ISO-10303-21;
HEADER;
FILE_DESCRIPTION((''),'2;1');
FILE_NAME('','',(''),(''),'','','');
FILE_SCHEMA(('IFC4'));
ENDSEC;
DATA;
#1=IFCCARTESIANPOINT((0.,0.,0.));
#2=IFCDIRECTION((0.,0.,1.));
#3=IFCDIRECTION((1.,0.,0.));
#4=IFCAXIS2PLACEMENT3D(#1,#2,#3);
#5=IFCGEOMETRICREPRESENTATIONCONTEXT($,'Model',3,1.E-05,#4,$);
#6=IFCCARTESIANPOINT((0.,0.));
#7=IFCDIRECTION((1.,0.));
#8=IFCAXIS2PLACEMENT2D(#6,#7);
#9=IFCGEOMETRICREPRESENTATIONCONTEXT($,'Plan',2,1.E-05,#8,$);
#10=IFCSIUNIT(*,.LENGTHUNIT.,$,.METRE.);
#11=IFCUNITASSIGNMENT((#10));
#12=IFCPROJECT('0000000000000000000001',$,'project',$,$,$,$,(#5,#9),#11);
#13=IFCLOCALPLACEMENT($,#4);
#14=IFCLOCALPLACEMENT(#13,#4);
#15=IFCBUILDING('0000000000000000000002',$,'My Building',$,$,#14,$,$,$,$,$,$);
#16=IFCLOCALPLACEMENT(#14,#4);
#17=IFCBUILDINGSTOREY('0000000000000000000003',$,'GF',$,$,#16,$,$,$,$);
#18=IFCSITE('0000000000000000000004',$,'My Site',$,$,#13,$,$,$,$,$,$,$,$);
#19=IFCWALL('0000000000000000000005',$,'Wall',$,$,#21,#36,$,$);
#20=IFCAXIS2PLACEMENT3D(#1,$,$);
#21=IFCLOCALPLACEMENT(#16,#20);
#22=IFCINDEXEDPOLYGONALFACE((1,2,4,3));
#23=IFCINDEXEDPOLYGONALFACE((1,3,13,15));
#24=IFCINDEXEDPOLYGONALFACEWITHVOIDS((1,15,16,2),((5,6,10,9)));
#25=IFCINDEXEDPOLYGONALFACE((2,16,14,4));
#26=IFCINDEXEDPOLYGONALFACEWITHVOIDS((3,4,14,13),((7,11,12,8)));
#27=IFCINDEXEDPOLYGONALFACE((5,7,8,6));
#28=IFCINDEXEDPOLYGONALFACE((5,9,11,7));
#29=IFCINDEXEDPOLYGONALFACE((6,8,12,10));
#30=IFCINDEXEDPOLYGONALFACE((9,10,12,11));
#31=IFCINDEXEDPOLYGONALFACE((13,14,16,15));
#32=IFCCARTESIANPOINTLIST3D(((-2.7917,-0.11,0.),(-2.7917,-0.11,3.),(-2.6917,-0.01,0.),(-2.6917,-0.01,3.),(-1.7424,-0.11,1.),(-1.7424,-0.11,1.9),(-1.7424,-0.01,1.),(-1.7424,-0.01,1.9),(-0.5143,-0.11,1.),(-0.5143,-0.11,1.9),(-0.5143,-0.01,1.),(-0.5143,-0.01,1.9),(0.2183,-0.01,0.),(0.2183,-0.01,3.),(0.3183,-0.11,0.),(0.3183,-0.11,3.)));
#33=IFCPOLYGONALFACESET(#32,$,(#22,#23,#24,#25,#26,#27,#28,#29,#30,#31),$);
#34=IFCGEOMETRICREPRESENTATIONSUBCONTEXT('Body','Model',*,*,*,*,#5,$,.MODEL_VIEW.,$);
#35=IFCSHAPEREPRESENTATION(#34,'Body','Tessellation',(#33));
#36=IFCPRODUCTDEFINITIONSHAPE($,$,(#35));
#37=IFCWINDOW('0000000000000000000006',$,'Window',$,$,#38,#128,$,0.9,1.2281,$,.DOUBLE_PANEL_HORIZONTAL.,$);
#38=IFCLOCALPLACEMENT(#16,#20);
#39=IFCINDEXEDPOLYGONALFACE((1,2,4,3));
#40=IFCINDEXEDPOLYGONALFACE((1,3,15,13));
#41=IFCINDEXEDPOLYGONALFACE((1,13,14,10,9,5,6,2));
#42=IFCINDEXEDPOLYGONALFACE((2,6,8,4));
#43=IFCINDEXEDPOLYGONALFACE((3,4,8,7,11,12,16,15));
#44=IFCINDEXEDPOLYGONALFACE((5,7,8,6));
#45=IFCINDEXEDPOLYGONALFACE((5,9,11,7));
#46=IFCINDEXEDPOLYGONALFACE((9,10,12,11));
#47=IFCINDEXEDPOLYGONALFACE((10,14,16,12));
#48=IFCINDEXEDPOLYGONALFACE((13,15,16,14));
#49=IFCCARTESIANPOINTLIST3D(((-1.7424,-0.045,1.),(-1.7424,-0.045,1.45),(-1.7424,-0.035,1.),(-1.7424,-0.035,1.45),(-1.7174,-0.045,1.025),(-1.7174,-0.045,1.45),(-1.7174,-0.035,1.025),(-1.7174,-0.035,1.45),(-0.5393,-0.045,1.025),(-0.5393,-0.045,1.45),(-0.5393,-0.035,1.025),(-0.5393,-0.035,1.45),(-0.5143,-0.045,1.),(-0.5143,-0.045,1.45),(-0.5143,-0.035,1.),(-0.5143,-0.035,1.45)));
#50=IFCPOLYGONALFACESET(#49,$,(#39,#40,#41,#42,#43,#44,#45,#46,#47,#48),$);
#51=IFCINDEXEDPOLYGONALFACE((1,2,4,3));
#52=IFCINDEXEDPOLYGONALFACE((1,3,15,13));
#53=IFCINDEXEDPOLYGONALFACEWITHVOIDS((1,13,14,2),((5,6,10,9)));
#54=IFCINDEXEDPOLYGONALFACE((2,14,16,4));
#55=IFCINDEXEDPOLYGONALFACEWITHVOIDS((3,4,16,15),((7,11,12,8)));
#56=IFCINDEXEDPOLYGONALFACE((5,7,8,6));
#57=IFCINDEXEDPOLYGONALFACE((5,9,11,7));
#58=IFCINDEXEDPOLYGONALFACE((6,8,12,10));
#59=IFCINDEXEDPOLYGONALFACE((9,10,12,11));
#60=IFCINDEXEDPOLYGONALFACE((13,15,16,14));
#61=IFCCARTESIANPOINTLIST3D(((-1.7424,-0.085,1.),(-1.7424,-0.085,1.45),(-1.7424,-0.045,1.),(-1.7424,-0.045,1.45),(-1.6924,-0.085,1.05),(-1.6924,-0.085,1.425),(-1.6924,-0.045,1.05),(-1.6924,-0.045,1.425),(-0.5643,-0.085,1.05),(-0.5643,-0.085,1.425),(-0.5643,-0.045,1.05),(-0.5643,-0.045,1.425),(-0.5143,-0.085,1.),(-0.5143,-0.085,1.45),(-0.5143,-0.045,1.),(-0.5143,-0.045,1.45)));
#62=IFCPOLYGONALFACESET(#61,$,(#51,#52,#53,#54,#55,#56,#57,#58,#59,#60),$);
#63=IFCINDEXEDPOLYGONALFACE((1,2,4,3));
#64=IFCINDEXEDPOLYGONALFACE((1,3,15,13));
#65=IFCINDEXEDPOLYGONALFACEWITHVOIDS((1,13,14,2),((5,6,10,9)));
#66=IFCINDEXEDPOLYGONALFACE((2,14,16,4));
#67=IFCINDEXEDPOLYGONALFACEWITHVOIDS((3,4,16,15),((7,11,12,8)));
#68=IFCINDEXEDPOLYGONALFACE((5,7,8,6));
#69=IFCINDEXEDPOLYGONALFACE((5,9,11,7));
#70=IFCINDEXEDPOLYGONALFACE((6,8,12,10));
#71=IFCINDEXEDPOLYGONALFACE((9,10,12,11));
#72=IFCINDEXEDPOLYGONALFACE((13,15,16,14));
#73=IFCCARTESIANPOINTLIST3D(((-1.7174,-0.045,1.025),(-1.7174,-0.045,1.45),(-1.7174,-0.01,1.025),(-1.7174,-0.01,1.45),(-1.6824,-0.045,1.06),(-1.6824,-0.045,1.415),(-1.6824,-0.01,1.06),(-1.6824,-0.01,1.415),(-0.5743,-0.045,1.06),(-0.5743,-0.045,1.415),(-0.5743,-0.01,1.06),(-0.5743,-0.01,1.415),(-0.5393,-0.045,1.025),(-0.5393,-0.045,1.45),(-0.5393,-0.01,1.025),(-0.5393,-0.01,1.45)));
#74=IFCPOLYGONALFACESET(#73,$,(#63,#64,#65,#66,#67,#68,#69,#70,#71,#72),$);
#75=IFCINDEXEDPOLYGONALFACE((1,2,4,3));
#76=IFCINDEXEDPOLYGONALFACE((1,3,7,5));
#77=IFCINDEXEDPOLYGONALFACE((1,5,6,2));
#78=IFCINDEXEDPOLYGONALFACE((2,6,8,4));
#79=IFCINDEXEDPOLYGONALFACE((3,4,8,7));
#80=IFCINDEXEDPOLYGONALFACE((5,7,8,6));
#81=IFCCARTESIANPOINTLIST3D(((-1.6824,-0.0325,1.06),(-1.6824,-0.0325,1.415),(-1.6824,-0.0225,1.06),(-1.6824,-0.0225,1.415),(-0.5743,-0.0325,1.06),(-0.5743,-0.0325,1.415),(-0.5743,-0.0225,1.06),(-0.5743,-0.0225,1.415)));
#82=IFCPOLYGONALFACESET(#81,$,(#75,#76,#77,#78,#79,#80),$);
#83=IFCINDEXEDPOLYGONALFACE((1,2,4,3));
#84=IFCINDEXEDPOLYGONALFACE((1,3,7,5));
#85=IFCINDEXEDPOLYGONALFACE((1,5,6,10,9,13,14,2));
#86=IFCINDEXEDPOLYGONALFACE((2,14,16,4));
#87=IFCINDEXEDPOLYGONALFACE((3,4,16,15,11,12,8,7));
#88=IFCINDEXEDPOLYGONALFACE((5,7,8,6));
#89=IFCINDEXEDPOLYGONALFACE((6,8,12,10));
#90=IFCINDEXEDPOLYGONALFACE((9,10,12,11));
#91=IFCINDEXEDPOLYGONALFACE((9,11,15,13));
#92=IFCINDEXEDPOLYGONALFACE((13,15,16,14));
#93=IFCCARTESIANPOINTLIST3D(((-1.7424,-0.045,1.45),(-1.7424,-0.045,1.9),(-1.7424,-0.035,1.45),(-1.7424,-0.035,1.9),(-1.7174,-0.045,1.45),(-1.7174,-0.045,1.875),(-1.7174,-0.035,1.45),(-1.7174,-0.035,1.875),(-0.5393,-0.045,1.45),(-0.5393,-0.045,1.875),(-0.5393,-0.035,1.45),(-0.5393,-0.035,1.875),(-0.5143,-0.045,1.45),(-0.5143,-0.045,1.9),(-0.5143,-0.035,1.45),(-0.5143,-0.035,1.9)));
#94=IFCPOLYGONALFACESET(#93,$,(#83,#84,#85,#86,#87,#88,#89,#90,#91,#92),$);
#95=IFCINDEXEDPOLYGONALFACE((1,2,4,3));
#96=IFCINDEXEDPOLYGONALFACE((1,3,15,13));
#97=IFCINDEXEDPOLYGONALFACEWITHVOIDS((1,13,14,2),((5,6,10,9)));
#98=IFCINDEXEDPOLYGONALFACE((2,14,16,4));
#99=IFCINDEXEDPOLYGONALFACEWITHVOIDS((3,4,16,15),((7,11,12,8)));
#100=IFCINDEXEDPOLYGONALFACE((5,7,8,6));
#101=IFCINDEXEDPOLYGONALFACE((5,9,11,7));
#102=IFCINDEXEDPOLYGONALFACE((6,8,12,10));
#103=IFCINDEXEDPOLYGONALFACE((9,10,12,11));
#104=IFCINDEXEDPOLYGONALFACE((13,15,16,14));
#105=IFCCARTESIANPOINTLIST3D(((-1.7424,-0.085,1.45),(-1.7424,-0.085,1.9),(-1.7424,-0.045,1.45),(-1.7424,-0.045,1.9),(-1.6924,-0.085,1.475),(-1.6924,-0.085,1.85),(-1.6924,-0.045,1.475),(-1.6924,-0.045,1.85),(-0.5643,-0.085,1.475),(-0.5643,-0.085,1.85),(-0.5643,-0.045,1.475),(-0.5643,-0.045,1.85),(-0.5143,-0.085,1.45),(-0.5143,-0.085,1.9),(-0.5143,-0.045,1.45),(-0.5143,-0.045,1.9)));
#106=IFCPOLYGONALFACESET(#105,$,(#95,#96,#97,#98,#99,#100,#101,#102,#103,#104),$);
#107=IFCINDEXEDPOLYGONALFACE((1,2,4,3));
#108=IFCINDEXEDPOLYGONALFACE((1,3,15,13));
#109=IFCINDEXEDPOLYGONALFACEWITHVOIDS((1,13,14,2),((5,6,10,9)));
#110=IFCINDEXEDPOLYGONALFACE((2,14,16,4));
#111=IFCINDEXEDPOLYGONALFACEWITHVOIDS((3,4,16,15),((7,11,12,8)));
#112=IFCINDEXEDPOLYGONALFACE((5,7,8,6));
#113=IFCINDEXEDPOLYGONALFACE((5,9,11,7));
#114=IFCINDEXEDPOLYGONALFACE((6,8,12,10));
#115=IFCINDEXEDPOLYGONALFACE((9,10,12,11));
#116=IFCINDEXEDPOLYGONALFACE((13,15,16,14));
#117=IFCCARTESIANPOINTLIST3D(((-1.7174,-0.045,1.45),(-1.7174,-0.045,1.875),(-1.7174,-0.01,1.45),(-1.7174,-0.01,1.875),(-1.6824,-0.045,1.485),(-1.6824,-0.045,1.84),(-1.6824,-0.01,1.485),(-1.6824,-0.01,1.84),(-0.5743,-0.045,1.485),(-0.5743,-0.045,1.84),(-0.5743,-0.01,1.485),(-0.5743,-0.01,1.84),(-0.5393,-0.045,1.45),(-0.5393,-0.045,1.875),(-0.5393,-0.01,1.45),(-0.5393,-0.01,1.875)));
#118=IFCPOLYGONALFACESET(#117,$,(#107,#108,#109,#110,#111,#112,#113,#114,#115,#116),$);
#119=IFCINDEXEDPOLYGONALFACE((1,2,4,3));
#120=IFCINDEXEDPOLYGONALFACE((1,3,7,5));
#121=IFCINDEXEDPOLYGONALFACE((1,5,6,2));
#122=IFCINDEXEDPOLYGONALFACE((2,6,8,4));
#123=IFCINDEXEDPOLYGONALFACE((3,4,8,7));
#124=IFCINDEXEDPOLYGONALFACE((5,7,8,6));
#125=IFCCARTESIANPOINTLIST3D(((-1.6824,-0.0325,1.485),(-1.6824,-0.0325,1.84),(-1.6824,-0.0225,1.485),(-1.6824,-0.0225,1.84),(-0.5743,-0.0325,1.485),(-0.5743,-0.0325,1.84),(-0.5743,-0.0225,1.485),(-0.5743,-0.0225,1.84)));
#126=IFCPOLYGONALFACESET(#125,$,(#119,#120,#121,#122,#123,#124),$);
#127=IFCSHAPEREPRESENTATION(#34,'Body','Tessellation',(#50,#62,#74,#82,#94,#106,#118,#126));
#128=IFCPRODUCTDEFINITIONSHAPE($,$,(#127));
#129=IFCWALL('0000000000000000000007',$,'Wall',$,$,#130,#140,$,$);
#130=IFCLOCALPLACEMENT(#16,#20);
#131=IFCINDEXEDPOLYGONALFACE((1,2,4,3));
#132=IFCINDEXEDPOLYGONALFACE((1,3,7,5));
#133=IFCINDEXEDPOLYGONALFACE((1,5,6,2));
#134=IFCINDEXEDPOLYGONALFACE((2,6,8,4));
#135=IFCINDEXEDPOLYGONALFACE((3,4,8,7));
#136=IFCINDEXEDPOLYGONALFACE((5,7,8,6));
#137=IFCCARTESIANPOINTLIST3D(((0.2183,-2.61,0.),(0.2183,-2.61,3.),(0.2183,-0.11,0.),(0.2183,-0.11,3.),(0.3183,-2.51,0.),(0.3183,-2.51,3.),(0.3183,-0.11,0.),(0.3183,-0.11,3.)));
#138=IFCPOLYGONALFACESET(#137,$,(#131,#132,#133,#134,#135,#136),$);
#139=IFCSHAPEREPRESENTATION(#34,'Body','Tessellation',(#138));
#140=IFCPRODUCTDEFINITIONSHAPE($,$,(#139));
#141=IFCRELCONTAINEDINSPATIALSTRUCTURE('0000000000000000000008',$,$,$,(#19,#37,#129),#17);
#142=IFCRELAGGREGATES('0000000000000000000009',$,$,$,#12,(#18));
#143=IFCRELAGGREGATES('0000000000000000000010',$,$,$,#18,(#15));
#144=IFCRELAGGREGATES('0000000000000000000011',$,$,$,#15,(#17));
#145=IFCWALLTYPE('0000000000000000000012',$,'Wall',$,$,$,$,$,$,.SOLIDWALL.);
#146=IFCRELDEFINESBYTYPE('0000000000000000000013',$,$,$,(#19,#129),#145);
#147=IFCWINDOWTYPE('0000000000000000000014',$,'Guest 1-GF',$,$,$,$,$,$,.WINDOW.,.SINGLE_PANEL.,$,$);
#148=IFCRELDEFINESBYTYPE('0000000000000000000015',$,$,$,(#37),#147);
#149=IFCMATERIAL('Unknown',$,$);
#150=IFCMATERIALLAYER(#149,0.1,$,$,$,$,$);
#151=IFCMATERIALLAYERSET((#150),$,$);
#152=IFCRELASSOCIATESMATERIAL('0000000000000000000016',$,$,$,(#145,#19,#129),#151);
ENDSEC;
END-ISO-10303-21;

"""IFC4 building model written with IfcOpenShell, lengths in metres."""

from ifc_helpers import new_model, entity, si_unit, frame, origin_with_axes, origin_2d_with_axis, place, context, subcontext, project, spatial, line, indexed_curve, outline, extrude, shape, source, transform, mapped, material, layer, layer_set, layer_usage, type_object, type_shapes, element, fill, save


model = new_model("IFC4")

# Units and contexts
model_context_1 = context("Model", 3, precision=1e-05, world=origin_with_axes())
plan_context = context("Plan", 2, precision=1e-05, world=origin_2d_with_axis())
body_context_1 = subcontext(model_context_1, "Body", "Model", "MODEL_VIEW")
body_context_2 = subcontext(plan_context, "Body", "Plan", "PLAN_VIEW")
ifc_project = project(units=[si_unit("LENGTHUNIT", "METRE")], contexts=[model_context_1, plan_context])

# Site, building, storey
site_placement = place(None, origin_with_axes())
site = spatial("IfcSite", under=ifc_project, at=site_placement, Name="My Site")
building_placement = place(site_placement, origin_with_axes())
building = spatial("IfcBuilding", under=site, at=building_placement, Name="My Building")
storey_placement = place(building_placement, origin_with_axes())
storey = spatial("IfcBuildingStorey", under=building, at=storey_placement, Name="GF")

# Shared definitions
ifc_material_1 = material(Name="Unknown")

# Shared definitions
ifc_layer_1 = layer(ifc_material_1, 0.1)
ifc_layer_set_1 = layer_set([ifc_layer_1])
wall_type = type_object("IfcWallType", Name="Wall", PredefinedType="SOLIDWALL", material=ifc_layer_set_1)

# Wall, opening, window
ifc_layer_usage_1 = layer_usage(ifc_layer_set_1, "AXIS2", "POSITIVE", 0.0)
wall_1_placement = place(storey_placement, frame((-2.7917, -0.11, 0.0), z_axis=(0.0, 0.0, 1.0), x_axis=(1.0, 0.0, 0.0)))
wall_1 = element("IfcWall", 1, at=wall_1_placement, inside=storey, type_object=wall_type, material=ifc_layer_usage_1, Name="Wall", context=body_context_1, shape_type="SweptSolid", body=[
    extrude(outline(indexed_curve([(0.0, 0.0), (0.1, 0.1), (3.01, 0.1), (3.11, 0.0)], segments=[line(1, 2, 3, 4, 1)])), origin_with_axes(), (0.0, 0.0, 1.0), 3.0),
])
shared_shape_1 = source(origin_with_axes(), body_context_1, "Body", "SweptSolid", [
    extrude(outline(indexed_curve([(0.0, 0.0), (1.2281, 0.0), (1.2281, 0.9), (0.0, 0.9)], segments=[line(1, 2, 3, 4, 1)])), frame((0.0, -0.6, 0.0), z_axis=(0.0, -1.0, 0.0), x_axis=(1.0, 0.0, 0.0)), (0.0, 0.0, -1.0), 1.2),
])
opening_1_placement = place(wall_1_placement, frame((1.0493, -0.025, 1.0), z_axis=(0.0, 0.0, 1.0), x_axis=(1.0, 0.0, 0.0)))
opening_1 = element("IfcOpeningElement", 2, at=opening_1_placement, cuts=wall_1, PredefinedType="OPENING", context=body_context_1, shape_type="MappedRepresentation", body=[
    mapped(shared_shape_1, transform((0.0, 0.0, 0.0), x_axis=(1.0, 0.0, 0.0), y_axis=(0.0, 1.0, 0.0), z_axis=(0.0, 0.0, 1.0), scale=1.0)),
])
window_type_1 = type_object("IfcWindowType", Name="Guest 1-GF", PartitioningType="SINGLE_PANEL", PredefinedType="WINDOW")
shared_shape_2 = source(origin_with_axes(), body_context_1, "Body", "SweptSolid", [
    extrude(outline(indexed_curve([(1.2281, 0.45), (1.2281, 0.0), (0.0, 0.0), (0.0, 0.45), (0.025, 0.45), (0.025, 0.025), (1.2031, 0.025), (1.2031, 0.45)], segments=[line(1, 2, 3, 4, 5, 6, 7, 8, 1)])), frame((0.0, 0.09, 0.0), z_axis=(0.0, -1.0, 0.0), x_axis=(1.0, 0.0, 0.0)), (0.0, 0.0, -1.0), 0.01),
    extrude(outline(indexed_curve([(0.0, 0.0), (1.2281, 0.0), (1.2281, 0.45), (0.0, 0.45)], segments=[line(1, 2, 3, 4, 1)]), holes=[indexed_curve([(0.05, 0.05), (1.1781, 0.05), (1.1781, 0.425), (0.05, 0.425)], segments=[line(1, 2, 3, 4, 1)])]), frame((0.0, 0.05, 0.0), z_axis=(0.0, -1.0, 0.0), x_axis=(1.0, 0.0, 0.0)), (0.0, 0.0, -1.0), 0.04),
    extrude(outline(indexed_curve([(0.0, 0.0), (1.1781, 0.0), (1.1781, 0.425), (0.0, 0.425)], segments=[line(1, 2, 3, 4, 1)]), holes=[indexed_curve([(0.035, 0.035), (1.1431, 0.035), (1.1431, 0.39), (0.035, 0.39)], segments=[line(1, 2, 3, 4, 1)])]), frame((0.025, 0.09, 0.025), z_axis=(0.0, -1.0, 0.0), x_axis=(1.0, 0.0, 0.0)), (0.0, 0.0, -1.0), 0.035),
    extrude(outline(indexed_curve([(0.035, 0.035), (1.1431, 0.035), (1.1431, 0.39), (0.035, 0.39)], segments=[line(1, 2, 3, 4, 1)])), frame((0.025, 0.1025, 0.025), z_axis=(0.0, -1.0, 0.0), x_axis=(1.0, 0.0, 0.0)), (0.0, 0.0, -1.0), 0.01),
    extrude(outline(indexed_curve([(0.0, 0.0), (0.0, 0.45), (1.2281, 0.45), (1.2281, 0.0), (1.2031, 0.0), (1.2031, 0.425), (0.025, 0.425), (0.025, 0.0)], segments=[line(1, 2, 3, 4, 5, 6, 7, 8, 1)])), frame((0.0, 0.09, 0.45), z_axis=(0.0, -1.0, 0.0), x_axis=(1.0, 0.0, 0.0)), (0.0, 0.0, -1.0), 0.01),
    extrude(outline(indexed_curve([(0.0, 0.0), (1.2281, 0.0), (1.2281, 0.45), (0.0, 0.45)], segments=[line(1, 2, 3, 4, 1)]), holes=[indexed_curve([(0.05, 0.025), (1.1781, 0.025), (1.1781, 0.4), (0.05, 0.4)], segments=[line(1, 2, 3, 4, 1)])]), frame((0.0, 0.05, 0.45), z_axis=(0.0, -1.0, 0.0), x_axis=(1.0, 0.0, 0.0)), (0.0, 0.0, -1.0), 0.04),
    extrude(outline(indexed_curve([(0.0, 0.0), (1.1781, 0.0), (1.1781, 0.425), (0.0, 0.425)], segments=[line(1, 2, 3, 4, 1)]), holes=[indexed_curve([(0.035, 0.035), (1.1431, 0.035), (1.1431, 0.39), (0.035, 0.39)], segments=[line(1, 2, 3, 4, 1)])]), frame((0.025, 0.09, 0.45), z_axis=(0.0, -1.0, 0.0), x_axis=(1.0, 0.0, 0.0)), (0.0, 0.0, -1.0), 0.035),
    extrude(outline(indexed_curve([(0.035, 0.035), (1.1431, 0.035), (1.1431, 0.39), (0.035, 0.39)], segments=[line(1, 2, 3, 4, 1)])), frame((0.025, 0.1025, 0.45), z_axis=(0.0, -1.0, 0.0), x_axis=(1.0, 0.0, 0.0)), (0.0, 0.0, -1.0), 0.01),
])
shared_shape_3 = source(origin_with_axes(), body_context_2, "Body", "Curve2D", [
    entity("IfcIndexedPolyCurve", entity("IfcCartesianPointList2D", [[0.05, 0.05], [1.1781, 0.05]])),
    entity("IfcIndexedPolyCurve", entity("IfcCartesianPointList2D", [[0.0, 0.1], [0.025, 0.1], [0.025, 0.09], [0.05, 0.09], [0.05, 0.05], [0.0, 0.05]]), [entity("IfcLineIndex", [1, 2, 3, 4, 5, 6, 1])]),
    entity("IfcIndexedPolyCurve", entity("IfcCartesianPointList2D", [[1.2281, 0.1], [1.2031, 0.1], [1.2031, 0.09], [1.1781, 0.09], [1.1781, 0.05], [1.2281, 0.05]]), [entity("IfcLineIndex", [1, 2, 3, 4, 5, 6, 1])]),
    entity("IfcIndexedPolyCurve", entity("IfcCartesianPointList2D", [[0.025, 0.09], [0.06, 0.09], [0.06, 0.125], [0.025, 0.125]]), [entity("IfcLineIndex", [1, 2, 3, 4, 1])]),
    entity("IfcIndexedPolyCurve", entity("IfcCartesianPointList2D", [[1.2031, 0.09], [1.1681, 0.09], [1.1681, 0.125], [1.2031, 0.125]]), [entity("IfcLineIndex", [1, 2, 3, 4, 1])]),
    entity("IfcIndexedPolyCurve", entity("IfcCartesianPointList2D", [[0.06, 0.09], [1.1681, 0.09]])),
    entity("IfcIndexedPolyCurve", entity("IfcCartesianPointList2D", [[0.06, 0.125], [1.1681, 0.125]])),
    entity("IfcIndexedPolyCurve", entity("IfcCartesianPointList2D", [[0.06, 0.1075], [1.1681, 0.1075]])),
])
type_shapes(window_type_1, [shared_shape_2, shared_shape_3])
window_1_placement = place(opening_1_placement, origin_with_axes())
window_1 = element("IfcWindow", 3, at=window_1_placement, inside=storey, type_object=window_type_1, Name="Window", OverallHeight=0.9, OverallWidth=1.2281, PartitioningType="DOUBLE_PANEL_HORIZONTAL", shapes=[
    shape(body_context_1, "Body", "MappedRepresentation", [mapped(shared_shape_2, transform((0.0, 0.0, 0.0), x_axis=(1.0, 0.0, 0.0), y_axis=(0.0, 1.0, 0.0), z_axis=(0.0, 0.0, 1.0), scale=1.0))]),
    shape(body_context_2, "Body", "MappedRepresentation", [mapped(shared_shape_3, transform((0.0, 0.0, 0.0), x_axis=(1.0, 0.0, 0.0), y_axis=(0.0, 1.0, 0.0), z_axis=(0.0, 0.0, 1.0), scale=1.0))]),
])
fill(opening_1, window_1)

# Wall
ifc_layer_usage_2 = layer_usage(ifc_layer_set_1, "AXIS2", "POSITIVE", 0.0)
wall_2_placement = place(storey_placement, frame((0.2183, -0.11, 0.0), z_axis=(0.0, 0.0, 1.0), x_axis=(0.0, -1.0, 0.0)))
element("IfcWall", 4, at=wall_2_placement, inside=storey, type_object=wall_type, material=ifc_layer_usage_2, Name="Wall", context=body_context_1, shape_type="SweptSolid", body=[
    extrude(outline(indexed_curve([(0.0, 0.0), (0.0, 0.1), (2.4, 0.1), (2.5, 0.0)], segments=[line(1, 2, 3, 4, 1)])), origin_with_axes(), (0.0, 0.0, 1.0), 3.0),
])

save(model, "model.ifc")
